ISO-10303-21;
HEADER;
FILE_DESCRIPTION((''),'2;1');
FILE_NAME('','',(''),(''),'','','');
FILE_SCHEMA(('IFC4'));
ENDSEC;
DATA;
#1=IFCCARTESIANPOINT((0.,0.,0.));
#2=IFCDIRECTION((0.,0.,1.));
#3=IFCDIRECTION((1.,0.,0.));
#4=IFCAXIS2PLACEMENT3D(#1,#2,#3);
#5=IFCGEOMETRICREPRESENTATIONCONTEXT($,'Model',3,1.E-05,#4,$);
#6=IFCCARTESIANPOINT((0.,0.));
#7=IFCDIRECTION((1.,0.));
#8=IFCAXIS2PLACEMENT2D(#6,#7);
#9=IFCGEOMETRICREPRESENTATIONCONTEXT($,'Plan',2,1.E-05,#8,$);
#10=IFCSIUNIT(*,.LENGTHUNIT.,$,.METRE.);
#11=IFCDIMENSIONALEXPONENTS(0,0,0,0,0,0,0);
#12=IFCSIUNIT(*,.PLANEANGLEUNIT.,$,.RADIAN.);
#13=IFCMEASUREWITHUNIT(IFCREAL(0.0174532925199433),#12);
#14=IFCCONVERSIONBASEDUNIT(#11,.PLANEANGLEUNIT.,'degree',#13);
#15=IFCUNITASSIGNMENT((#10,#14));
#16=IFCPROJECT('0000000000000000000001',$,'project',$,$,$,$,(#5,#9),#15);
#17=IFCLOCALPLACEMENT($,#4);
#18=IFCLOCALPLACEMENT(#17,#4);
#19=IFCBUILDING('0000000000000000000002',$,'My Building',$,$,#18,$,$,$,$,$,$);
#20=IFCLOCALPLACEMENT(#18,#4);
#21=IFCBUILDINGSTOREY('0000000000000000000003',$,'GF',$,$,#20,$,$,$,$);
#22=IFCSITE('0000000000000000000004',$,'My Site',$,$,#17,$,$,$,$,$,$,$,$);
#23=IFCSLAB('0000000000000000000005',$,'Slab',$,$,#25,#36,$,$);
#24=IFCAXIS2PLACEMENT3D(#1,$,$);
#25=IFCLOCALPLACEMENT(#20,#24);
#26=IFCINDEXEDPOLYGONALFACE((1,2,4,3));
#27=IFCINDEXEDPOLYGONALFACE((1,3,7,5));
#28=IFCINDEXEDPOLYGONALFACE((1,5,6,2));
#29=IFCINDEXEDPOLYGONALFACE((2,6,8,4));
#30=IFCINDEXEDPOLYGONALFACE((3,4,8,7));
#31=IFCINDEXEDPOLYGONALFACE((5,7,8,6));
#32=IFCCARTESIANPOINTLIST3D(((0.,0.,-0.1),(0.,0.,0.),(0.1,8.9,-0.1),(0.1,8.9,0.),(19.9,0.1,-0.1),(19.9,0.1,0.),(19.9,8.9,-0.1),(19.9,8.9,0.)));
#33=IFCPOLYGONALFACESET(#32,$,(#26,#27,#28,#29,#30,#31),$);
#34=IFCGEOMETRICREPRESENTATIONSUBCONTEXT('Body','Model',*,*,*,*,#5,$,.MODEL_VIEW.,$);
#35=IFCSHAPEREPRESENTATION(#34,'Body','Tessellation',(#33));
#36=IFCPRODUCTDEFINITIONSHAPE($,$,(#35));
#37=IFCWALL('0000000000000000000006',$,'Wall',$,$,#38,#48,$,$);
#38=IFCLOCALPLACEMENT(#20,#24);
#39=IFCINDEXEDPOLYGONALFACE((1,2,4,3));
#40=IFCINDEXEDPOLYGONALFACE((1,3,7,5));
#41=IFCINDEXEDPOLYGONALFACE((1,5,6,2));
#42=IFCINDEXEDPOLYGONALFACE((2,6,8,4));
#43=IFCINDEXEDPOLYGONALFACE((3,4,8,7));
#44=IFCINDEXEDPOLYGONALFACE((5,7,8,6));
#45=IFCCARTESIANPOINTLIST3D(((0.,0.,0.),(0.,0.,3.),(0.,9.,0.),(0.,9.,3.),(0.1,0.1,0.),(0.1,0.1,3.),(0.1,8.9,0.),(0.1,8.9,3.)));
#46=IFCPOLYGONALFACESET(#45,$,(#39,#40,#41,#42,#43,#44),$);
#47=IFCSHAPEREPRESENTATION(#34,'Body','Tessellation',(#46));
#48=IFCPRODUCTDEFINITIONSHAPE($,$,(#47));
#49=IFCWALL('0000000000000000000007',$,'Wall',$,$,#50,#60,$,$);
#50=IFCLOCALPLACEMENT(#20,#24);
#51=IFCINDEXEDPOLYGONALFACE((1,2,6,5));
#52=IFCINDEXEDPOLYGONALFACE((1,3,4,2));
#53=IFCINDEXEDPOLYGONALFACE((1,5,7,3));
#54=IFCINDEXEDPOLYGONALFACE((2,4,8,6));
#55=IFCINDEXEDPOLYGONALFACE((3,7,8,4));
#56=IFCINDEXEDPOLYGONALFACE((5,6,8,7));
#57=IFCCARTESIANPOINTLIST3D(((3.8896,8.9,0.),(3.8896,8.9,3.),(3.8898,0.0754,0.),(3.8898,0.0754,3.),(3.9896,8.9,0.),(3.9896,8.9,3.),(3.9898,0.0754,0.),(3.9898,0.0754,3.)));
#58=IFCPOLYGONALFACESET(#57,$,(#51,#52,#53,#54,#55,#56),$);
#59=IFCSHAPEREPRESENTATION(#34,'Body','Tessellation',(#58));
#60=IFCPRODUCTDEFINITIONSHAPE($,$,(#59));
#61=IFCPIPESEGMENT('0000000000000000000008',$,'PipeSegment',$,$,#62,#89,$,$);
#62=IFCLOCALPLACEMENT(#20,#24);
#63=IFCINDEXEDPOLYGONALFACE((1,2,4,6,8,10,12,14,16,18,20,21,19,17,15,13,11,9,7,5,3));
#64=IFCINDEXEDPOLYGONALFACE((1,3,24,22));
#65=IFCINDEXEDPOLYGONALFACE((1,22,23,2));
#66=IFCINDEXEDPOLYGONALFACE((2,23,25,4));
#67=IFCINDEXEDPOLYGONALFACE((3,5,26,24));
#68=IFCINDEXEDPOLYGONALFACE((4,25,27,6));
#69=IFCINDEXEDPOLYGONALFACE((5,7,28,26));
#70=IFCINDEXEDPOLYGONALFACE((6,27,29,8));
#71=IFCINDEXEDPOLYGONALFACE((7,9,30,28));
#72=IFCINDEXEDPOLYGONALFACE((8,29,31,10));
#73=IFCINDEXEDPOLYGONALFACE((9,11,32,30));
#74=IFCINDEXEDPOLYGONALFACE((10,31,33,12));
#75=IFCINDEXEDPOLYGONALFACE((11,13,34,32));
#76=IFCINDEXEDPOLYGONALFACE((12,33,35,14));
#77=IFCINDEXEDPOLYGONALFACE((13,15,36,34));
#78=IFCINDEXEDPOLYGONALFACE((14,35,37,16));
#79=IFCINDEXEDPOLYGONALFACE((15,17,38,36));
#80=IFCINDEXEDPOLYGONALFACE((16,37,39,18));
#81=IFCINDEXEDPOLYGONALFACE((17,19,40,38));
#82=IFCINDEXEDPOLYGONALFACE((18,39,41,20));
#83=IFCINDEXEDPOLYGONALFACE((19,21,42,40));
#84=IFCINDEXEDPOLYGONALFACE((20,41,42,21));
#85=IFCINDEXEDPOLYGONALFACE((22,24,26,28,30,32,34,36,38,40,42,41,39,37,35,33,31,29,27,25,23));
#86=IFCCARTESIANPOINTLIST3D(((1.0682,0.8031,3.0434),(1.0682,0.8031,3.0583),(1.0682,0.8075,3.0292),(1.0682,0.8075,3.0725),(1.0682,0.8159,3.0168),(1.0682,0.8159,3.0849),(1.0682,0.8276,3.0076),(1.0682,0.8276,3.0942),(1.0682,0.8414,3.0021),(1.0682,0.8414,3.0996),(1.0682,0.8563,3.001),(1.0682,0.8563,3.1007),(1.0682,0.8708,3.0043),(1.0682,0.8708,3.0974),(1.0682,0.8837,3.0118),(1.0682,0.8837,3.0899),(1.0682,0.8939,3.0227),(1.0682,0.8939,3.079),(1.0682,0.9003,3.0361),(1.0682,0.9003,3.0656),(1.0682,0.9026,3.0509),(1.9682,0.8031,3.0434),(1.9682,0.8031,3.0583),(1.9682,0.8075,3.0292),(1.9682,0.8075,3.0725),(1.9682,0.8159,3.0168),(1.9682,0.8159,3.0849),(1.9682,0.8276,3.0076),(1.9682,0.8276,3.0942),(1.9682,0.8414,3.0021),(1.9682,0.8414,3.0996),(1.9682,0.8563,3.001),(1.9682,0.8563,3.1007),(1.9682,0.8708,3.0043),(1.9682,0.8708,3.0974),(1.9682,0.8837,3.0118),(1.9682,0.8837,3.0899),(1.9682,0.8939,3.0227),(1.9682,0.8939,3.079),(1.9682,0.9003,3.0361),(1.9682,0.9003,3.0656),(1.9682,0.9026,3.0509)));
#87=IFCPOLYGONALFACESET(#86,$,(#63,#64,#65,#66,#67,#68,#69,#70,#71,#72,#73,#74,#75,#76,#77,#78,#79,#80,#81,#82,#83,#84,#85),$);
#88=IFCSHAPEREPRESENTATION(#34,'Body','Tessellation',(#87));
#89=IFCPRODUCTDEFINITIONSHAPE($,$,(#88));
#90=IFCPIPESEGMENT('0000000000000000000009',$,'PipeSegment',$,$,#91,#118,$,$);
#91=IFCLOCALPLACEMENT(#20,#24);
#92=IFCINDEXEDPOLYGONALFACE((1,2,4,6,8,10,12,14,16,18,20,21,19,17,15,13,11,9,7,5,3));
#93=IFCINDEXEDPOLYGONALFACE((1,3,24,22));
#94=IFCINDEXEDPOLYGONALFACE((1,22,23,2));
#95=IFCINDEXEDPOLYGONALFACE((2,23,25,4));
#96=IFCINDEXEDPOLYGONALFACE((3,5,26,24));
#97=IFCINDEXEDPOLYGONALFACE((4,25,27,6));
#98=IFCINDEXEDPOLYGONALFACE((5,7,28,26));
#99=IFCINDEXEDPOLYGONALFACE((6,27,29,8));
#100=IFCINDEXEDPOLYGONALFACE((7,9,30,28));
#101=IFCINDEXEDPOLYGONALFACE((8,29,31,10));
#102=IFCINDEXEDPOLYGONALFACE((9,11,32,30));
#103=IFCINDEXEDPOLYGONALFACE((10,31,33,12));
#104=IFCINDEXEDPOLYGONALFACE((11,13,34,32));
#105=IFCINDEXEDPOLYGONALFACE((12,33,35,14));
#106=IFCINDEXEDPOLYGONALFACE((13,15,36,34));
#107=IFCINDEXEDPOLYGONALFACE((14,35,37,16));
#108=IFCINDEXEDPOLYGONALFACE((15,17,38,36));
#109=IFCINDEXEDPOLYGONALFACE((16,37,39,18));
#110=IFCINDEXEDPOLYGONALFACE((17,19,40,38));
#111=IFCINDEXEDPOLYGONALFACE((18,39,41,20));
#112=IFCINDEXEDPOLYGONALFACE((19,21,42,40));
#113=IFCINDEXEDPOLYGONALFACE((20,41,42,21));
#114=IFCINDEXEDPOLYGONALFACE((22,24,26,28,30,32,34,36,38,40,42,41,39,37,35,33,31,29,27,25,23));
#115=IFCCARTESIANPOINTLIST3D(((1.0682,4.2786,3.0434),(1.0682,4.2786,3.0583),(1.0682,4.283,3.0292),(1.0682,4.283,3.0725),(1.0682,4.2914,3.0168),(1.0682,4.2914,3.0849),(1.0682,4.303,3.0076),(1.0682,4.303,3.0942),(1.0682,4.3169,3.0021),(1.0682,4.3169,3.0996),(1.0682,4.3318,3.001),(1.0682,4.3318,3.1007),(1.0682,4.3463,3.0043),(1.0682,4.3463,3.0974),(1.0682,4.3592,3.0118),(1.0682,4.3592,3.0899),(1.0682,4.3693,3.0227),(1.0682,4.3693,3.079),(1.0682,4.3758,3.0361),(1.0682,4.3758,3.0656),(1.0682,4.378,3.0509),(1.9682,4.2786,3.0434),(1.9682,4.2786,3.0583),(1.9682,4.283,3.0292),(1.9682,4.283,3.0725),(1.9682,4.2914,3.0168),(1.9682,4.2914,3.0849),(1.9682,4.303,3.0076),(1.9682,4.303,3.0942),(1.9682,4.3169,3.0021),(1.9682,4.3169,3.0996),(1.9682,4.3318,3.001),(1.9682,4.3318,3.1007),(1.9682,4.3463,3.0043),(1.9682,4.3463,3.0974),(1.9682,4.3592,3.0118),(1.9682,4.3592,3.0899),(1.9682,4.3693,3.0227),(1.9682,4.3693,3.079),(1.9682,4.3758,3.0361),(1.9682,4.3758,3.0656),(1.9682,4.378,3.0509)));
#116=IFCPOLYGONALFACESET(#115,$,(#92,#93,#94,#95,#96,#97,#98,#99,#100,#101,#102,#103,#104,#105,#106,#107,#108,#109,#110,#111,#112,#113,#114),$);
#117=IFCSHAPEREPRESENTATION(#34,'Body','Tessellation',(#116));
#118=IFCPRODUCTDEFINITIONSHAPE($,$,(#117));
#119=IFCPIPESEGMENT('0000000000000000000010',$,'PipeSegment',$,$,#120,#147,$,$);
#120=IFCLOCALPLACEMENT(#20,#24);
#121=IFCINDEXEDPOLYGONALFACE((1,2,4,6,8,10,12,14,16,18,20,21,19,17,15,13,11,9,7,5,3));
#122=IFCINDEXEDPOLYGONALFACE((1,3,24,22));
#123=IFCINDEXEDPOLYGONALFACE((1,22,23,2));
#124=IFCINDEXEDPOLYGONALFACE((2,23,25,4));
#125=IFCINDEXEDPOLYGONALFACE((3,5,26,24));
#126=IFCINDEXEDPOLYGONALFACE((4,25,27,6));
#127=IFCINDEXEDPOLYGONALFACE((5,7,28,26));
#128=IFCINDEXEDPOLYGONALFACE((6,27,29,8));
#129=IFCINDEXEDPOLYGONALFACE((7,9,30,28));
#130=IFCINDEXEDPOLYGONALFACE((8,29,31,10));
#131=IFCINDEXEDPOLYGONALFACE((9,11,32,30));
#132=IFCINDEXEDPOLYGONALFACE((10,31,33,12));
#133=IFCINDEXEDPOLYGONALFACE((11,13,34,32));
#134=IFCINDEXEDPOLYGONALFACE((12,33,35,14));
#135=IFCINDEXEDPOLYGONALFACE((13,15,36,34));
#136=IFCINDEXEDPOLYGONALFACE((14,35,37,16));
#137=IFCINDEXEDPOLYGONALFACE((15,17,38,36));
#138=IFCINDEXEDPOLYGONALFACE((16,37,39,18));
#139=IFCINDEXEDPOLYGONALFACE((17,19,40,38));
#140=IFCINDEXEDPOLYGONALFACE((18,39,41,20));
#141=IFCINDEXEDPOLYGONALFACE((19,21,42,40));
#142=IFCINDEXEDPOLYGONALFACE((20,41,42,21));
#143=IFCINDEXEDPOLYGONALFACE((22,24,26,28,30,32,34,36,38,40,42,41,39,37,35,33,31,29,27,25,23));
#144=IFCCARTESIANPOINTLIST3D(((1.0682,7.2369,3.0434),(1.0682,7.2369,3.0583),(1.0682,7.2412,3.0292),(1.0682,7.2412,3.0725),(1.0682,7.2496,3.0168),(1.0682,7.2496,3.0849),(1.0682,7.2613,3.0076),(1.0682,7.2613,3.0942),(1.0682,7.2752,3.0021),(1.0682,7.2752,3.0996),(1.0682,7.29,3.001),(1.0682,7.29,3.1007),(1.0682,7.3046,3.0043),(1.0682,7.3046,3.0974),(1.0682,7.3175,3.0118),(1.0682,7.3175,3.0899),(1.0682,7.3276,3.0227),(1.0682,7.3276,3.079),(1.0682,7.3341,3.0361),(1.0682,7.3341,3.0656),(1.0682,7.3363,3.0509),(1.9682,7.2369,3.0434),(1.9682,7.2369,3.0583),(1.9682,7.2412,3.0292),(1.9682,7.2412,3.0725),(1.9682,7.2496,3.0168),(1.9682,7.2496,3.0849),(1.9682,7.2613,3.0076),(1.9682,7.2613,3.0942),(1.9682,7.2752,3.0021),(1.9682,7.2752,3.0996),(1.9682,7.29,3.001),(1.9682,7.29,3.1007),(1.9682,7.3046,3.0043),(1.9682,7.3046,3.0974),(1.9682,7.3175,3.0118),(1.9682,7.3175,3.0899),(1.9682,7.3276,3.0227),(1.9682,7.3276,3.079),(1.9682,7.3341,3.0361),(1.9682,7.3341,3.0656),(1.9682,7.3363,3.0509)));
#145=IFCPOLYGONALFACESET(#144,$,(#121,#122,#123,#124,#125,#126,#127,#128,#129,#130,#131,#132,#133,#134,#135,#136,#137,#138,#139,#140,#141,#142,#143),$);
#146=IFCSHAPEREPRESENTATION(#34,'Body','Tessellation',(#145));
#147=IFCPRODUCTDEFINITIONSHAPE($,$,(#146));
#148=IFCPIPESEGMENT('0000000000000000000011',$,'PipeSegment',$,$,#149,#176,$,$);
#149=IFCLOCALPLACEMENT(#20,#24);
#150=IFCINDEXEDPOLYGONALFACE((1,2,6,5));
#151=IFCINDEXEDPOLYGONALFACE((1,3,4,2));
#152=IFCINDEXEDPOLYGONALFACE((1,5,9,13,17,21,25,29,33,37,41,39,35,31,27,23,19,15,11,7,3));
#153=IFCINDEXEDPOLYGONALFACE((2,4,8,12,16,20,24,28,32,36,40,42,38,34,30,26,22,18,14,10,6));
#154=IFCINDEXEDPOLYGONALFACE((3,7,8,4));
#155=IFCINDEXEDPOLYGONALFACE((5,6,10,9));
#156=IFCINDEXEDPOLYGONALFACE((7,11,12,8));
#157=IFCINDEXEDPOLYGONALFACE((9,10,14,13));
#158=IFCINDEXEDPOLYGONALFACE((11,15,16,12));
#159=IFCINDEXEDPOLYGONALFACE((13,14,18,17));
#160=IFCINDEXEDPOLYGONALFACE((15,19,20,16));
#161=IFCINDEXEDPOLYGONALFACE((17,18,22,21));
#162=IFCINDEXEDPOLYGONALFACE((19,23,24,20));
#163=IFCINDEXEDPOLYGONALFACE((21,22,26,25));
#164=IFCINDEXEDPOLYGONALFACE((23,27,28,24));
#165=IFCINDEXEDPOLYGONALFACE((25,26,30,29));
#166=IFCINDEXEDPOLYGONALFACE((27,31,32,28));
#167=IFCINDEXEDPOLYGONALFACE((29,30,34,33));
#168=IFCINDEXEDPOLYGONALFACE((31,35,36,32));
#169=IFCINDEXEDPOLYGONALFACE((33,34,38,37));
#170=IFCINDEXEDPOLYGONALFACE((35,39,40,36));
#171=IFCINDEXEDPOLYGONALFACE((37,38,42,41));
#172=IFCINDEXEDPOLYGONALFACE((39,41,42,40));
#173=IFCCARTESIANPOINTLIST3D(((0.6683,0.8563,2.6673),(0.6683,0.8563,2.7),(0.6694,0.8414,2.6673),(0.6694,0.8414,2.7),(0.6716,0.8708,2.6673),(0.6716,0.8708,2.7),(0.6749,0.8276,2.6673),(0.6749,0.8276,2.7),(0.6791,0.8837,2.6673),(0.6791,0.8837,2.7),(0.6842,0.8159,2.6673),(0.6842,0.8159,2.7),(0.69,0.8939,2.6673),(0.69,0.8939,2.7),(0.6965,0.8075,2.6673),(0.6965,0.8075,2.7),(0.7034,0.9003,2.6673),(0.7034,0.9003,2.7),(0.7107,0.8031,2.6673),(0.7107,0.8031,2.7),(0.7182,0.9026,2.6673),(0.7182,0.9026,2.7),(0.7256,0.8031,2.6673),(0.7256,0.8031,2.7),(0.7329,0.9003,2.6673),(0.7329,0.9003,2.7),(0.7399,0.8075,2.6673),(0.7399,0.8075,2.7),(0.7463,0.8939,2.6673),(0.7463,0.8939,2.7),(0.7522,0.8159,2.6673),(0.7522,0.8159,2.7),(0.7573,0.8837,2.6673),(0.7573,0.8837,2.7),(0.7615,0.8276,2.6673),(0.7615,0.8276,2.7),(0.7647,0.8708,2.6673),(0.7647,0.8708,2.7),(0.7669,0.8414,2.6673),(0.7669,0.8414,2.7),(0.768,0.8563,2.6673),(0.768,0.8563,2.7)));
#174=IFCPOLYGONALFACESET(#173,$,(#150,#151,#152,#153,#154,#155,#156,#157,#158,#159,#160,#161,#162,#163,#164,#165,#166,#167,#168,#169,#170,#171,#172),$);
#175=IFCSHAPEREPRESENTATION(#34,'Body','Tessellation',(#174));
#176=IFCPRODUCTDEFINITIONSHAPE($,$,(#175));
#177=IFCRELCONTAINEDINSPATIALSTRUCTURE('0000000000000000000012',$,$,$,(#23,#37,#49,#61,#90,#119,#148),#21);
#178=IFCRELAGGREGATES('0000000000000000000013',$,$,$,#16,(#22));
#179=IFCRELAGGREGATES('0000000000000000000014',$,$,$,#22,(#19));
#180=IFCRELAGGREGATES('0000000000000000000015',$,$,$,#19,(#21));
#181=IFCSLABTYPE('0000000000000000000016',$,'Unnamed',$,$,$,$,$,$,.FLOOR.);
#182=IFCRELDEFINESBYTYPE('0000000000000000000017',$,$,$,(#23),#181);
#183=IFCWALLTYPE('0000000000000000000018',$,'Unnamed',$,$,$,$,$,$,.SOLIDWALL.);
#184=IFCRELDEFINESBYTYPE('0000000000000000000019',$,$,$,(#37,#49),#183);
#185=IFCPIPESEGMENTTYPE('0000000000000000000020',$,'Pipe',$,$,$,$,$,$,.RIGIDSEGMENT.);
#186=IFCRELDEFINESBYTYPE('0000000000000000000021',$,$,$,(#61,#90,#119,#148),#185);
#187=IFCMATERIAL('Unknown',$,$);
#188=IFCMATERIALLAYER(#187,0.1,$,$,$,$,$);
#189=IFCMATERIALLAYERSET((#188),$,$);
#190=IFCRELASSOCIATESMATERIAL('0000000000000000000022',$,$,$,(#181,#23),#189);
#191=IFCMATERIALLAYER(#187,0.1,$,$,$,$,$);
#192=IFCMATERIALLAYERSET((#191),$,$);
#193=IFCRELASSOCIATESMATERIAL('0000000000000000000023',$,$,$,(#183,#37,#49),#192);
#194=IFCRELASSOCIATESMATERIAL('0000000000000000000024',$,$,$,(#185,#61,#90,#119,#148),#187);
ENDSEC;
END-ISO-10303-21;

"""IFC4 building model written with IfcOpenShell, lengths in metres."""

from ifc_helpers import new_model, entity, si_unit, converted_unit, frame, origin_with_axes, origin_2d_with_axis, place, context, subcontext, project, spatial, line, indexed_curve, circle, outline, extrude, material, layer, layer_set, layer_usage, material_profile, profile_set, profile_usage, type_object, element, save


model = new_model("IFC4")

# Units and contexts
model_context = context("Model", 3, precision=1e-05, world=origin_with_axes())
plan_context = context("Plan", 2, precision=1e-05, world=origin_2d_with_axis())
body_context_1 = subcontext(model_context, "Body", "Model", "MODEL_VIEW")
ifc_project = project(units=[si_unit("LENGTHUNIT", "METRE"), converted_unit("PLANEANGLEUNIT", "degree", entity("IfcReal", 0.0174532925199433), si_unit("PLANEANGLEUNIT", "RADIAN"), dimensions=[0, 0, 0, 0, 0, 0, 0])], contexts=[model_context, plan_context])

# Site, building, storey
site_placement = place(None, origin_with_axes())
site = spatial("IfcSite", under=ifc_project, at=site_placement, Name="My Site")
building_placement = place(site_placement, origin_with_axes())
building = spatial("IfcBuilding", under=site, at=building_placement, Name="My Building")
storey_placement = place(building_placement, origin_with_axes())
storey = spatial("IfcBuildingStorey", under=building, at=storey_placement, Name="GF")

# Slab
ifc_material = material(Name="Unknown")
ifc_layer_1 = layer(ifc_material, 0.1)
ifc_layer_set_1 = layer_set([ifc_layer_1])
ifc_layer_usage_1 = layer_usage(ifc_layer_set_1, "AXIS3", "POSITIVE", -0.1)
slab_type = type_object("IfcSlabType", Name="Unnamed", PredefinedType="FLOOR", material=ifc_layer_set_1)
slab_placement = place(storey_placement, frame((0.1, 8.9, 0.0), z_axis=(0.0, 0.0, 1.0), x_axis=(1.0, 0.0, 0.0)))
element("IfcSlab", 1, at=slab_placement, inside=storey, type_object=slab_type, material=ifc_layer_usage_1, Name="Slab", context=body_context_1, shape_type="SweptSolid", body=[
    extrude(outline(indexed_curve([(0.0, 0.0), (19.8, 0.0), (19.8, -8.8), (-0.1, -8.9), (0.0, 0.0)])), frame((0.0, 0.0, -0.1), z_axis=(0.0, 0.0, 1.0), x_axis=(1.0, 0.0, 0.0)), (0.0, 0.0, 1.0), 0.1),
])

# Shared definitions
ifc_layer_2 = layer(ifc_material, 0.1)
ifc_layer_set_2 = layer_set([ifc_layer_2])
wall_type = type_object("IfcWallType", Name="Unnamed", PredefinedType="SOLIDWALL", material=ifc_layer_set_2)

# Walls
ifc_layer_usage_2 = layer_usage(ifc_layer_set_2, "AXIS2", "POSITIVE", 0.0)
wall_1_placement = place(storey_placement, frame((0.0, 9.0, 0.0), z_axis=(0.0, 0.0, 1.0), x_axis=(0.0, -1.0, 0.0)))
element("IfcWall", 2, at=wall_1_placement, inside=storey, type_object=wall_type, material=ifc_layer_usage_2, Name="Wall", context=body_context_1, shape_type="SweptSolid", body=[
    extrude(outline(indexed_curve([(0.0, 0.0), (0.1, 0.1), (8.9, 0.1), (9.0, 0.0)], segments=[line(1, 2, 3, 4, 1)])), origin_with_axes(), (0.0, 0.0, 1.0), 3.0),
])
ifc_layer_usage_3 = layer_usage(ifc_layer_set_2, "AXIS2", "POSITIVE", 0.0)
wall_2_placement = place(storey_placement, frame((3.9898, 0.0754, 0.0), z_axis=(0.0, 0.0, 1.0), x_axis=(-0.000021, 1.0, 0.0)))
element("IfcWall", 3, at=wall_2_placement, inside=storey, type_object=wall_type, material=ifc_layer_usage_3, Name="Wall", context=body_context_1, shape_type="SweptSolid", body=[
    extrude(outline(indexed_curve([(0.0, 0.0), (0.0, 0.1), (8.8246, 0.1), (8.8246, 0.0)], segments=[line(1, 2, 3, 4, 1)])), origin_with_axes(), (0.0, 0.0, 1.0), 3.0),
])

# Pipe segments
ifc_material_profile = material_profile(ifc_material, circle(Radius=0.05))
ifc_profile_set = profile_set([ifc_material_profile])
ifc_profile_usage_1 = profile_usage(ifc_profile_set, cardinal=5)
pipe_segment_type = type_object("IfcPipeSegmentType", Name="Pipe", PredefinedType="RIGIDSEGMENT", material=ifc_profile_set)
pipe_segment_1_placement = place(storey_placement, frame((1.0682, 0.8526, 3.0509), z_axis=(1.0, 0.0, 0.0), x_axis=(0.0, 1.0, 0.0)))
element("IfcPipeSegment", 4, at=pipe_segment_1_placement, inside=storey, type_object=pipe_segment_type, material=ifc_profile_usage_1, Name="PipeSegment", context=body_context_1, shape_type="SweptSolid", body=[
    extrude(circle(Radius=0.05), origin_with_axes(), (0.0, 0.0, 1.0), 0.9),
])
ifc_profile_usage_2 = profile_usage(ifc_profile_set, cardinal=5)
pipe_segment_2_placement = place(storey_placement, frame((1.0682, 4.328, 3.0509), z_axis=(1.0, 0.0, 0.0), x_axis=(0.0, 1.0, 0.0)))
element("IfcPipeSegment", 5, at=pipe_segment_2_placement, inside=storey, type_object=pipe_segment_type, material=ifc_profile_usage_2, Name="PipeSegment", context=body_context_1, shape_type="SweptSolid", body=[
    extrude(circle(Radius=0.05), origin_with_axes(), (0.0, 0.0, 1.0), 0.9),
])
ifc_profile_usage_3 = profile_usage(ifc_profile_set, cardinal=5)
pipe_segment_3_placement = place(storey_placement, frame((1.0682, 7.2863, 3.0509), z_axis=(1.0, 0.0, 0.0), x_axis=(0.0, 1.0, 0.0)))
element("IfcPipeSegment", 6, at=pipe_segment_3_placement, inside=storey, type_object=pipe_segment_type, material=ifc_profile_usage_3, Name="PipeSegment", context=body_context_1, shape_type="SweptSolid", body=[
    extrude(circle(Radius=0.05), origin_with_axes(), (0.0, 0.0, 1.0), 0.9),
])
ifc_profile_usage_4 = profile_usage(ifc_profile_set, cardinal=5)
pipe_segment_4_placement = place(storey_placement, frame((0.7182, 0.8526, 2.7), z_axis=(0.0, 0.0, -1.0), x_axis=(0.0, 1.0, 0.0)))
element("IfcPipeSegment", 7, at=pipe_segment_4_placement, inside=storey, type_object=pipe_segment_type, material=ifc_profile_usage_4, Name="PipeSegment", context=body_context_1, shape_type="SweptSolid", body=[
    extrude(circle(Radius=0.05), origin_with_axes(), (0.0, 0.0, 1.0), 0.0328),
])

save(model, "model.ifc")
